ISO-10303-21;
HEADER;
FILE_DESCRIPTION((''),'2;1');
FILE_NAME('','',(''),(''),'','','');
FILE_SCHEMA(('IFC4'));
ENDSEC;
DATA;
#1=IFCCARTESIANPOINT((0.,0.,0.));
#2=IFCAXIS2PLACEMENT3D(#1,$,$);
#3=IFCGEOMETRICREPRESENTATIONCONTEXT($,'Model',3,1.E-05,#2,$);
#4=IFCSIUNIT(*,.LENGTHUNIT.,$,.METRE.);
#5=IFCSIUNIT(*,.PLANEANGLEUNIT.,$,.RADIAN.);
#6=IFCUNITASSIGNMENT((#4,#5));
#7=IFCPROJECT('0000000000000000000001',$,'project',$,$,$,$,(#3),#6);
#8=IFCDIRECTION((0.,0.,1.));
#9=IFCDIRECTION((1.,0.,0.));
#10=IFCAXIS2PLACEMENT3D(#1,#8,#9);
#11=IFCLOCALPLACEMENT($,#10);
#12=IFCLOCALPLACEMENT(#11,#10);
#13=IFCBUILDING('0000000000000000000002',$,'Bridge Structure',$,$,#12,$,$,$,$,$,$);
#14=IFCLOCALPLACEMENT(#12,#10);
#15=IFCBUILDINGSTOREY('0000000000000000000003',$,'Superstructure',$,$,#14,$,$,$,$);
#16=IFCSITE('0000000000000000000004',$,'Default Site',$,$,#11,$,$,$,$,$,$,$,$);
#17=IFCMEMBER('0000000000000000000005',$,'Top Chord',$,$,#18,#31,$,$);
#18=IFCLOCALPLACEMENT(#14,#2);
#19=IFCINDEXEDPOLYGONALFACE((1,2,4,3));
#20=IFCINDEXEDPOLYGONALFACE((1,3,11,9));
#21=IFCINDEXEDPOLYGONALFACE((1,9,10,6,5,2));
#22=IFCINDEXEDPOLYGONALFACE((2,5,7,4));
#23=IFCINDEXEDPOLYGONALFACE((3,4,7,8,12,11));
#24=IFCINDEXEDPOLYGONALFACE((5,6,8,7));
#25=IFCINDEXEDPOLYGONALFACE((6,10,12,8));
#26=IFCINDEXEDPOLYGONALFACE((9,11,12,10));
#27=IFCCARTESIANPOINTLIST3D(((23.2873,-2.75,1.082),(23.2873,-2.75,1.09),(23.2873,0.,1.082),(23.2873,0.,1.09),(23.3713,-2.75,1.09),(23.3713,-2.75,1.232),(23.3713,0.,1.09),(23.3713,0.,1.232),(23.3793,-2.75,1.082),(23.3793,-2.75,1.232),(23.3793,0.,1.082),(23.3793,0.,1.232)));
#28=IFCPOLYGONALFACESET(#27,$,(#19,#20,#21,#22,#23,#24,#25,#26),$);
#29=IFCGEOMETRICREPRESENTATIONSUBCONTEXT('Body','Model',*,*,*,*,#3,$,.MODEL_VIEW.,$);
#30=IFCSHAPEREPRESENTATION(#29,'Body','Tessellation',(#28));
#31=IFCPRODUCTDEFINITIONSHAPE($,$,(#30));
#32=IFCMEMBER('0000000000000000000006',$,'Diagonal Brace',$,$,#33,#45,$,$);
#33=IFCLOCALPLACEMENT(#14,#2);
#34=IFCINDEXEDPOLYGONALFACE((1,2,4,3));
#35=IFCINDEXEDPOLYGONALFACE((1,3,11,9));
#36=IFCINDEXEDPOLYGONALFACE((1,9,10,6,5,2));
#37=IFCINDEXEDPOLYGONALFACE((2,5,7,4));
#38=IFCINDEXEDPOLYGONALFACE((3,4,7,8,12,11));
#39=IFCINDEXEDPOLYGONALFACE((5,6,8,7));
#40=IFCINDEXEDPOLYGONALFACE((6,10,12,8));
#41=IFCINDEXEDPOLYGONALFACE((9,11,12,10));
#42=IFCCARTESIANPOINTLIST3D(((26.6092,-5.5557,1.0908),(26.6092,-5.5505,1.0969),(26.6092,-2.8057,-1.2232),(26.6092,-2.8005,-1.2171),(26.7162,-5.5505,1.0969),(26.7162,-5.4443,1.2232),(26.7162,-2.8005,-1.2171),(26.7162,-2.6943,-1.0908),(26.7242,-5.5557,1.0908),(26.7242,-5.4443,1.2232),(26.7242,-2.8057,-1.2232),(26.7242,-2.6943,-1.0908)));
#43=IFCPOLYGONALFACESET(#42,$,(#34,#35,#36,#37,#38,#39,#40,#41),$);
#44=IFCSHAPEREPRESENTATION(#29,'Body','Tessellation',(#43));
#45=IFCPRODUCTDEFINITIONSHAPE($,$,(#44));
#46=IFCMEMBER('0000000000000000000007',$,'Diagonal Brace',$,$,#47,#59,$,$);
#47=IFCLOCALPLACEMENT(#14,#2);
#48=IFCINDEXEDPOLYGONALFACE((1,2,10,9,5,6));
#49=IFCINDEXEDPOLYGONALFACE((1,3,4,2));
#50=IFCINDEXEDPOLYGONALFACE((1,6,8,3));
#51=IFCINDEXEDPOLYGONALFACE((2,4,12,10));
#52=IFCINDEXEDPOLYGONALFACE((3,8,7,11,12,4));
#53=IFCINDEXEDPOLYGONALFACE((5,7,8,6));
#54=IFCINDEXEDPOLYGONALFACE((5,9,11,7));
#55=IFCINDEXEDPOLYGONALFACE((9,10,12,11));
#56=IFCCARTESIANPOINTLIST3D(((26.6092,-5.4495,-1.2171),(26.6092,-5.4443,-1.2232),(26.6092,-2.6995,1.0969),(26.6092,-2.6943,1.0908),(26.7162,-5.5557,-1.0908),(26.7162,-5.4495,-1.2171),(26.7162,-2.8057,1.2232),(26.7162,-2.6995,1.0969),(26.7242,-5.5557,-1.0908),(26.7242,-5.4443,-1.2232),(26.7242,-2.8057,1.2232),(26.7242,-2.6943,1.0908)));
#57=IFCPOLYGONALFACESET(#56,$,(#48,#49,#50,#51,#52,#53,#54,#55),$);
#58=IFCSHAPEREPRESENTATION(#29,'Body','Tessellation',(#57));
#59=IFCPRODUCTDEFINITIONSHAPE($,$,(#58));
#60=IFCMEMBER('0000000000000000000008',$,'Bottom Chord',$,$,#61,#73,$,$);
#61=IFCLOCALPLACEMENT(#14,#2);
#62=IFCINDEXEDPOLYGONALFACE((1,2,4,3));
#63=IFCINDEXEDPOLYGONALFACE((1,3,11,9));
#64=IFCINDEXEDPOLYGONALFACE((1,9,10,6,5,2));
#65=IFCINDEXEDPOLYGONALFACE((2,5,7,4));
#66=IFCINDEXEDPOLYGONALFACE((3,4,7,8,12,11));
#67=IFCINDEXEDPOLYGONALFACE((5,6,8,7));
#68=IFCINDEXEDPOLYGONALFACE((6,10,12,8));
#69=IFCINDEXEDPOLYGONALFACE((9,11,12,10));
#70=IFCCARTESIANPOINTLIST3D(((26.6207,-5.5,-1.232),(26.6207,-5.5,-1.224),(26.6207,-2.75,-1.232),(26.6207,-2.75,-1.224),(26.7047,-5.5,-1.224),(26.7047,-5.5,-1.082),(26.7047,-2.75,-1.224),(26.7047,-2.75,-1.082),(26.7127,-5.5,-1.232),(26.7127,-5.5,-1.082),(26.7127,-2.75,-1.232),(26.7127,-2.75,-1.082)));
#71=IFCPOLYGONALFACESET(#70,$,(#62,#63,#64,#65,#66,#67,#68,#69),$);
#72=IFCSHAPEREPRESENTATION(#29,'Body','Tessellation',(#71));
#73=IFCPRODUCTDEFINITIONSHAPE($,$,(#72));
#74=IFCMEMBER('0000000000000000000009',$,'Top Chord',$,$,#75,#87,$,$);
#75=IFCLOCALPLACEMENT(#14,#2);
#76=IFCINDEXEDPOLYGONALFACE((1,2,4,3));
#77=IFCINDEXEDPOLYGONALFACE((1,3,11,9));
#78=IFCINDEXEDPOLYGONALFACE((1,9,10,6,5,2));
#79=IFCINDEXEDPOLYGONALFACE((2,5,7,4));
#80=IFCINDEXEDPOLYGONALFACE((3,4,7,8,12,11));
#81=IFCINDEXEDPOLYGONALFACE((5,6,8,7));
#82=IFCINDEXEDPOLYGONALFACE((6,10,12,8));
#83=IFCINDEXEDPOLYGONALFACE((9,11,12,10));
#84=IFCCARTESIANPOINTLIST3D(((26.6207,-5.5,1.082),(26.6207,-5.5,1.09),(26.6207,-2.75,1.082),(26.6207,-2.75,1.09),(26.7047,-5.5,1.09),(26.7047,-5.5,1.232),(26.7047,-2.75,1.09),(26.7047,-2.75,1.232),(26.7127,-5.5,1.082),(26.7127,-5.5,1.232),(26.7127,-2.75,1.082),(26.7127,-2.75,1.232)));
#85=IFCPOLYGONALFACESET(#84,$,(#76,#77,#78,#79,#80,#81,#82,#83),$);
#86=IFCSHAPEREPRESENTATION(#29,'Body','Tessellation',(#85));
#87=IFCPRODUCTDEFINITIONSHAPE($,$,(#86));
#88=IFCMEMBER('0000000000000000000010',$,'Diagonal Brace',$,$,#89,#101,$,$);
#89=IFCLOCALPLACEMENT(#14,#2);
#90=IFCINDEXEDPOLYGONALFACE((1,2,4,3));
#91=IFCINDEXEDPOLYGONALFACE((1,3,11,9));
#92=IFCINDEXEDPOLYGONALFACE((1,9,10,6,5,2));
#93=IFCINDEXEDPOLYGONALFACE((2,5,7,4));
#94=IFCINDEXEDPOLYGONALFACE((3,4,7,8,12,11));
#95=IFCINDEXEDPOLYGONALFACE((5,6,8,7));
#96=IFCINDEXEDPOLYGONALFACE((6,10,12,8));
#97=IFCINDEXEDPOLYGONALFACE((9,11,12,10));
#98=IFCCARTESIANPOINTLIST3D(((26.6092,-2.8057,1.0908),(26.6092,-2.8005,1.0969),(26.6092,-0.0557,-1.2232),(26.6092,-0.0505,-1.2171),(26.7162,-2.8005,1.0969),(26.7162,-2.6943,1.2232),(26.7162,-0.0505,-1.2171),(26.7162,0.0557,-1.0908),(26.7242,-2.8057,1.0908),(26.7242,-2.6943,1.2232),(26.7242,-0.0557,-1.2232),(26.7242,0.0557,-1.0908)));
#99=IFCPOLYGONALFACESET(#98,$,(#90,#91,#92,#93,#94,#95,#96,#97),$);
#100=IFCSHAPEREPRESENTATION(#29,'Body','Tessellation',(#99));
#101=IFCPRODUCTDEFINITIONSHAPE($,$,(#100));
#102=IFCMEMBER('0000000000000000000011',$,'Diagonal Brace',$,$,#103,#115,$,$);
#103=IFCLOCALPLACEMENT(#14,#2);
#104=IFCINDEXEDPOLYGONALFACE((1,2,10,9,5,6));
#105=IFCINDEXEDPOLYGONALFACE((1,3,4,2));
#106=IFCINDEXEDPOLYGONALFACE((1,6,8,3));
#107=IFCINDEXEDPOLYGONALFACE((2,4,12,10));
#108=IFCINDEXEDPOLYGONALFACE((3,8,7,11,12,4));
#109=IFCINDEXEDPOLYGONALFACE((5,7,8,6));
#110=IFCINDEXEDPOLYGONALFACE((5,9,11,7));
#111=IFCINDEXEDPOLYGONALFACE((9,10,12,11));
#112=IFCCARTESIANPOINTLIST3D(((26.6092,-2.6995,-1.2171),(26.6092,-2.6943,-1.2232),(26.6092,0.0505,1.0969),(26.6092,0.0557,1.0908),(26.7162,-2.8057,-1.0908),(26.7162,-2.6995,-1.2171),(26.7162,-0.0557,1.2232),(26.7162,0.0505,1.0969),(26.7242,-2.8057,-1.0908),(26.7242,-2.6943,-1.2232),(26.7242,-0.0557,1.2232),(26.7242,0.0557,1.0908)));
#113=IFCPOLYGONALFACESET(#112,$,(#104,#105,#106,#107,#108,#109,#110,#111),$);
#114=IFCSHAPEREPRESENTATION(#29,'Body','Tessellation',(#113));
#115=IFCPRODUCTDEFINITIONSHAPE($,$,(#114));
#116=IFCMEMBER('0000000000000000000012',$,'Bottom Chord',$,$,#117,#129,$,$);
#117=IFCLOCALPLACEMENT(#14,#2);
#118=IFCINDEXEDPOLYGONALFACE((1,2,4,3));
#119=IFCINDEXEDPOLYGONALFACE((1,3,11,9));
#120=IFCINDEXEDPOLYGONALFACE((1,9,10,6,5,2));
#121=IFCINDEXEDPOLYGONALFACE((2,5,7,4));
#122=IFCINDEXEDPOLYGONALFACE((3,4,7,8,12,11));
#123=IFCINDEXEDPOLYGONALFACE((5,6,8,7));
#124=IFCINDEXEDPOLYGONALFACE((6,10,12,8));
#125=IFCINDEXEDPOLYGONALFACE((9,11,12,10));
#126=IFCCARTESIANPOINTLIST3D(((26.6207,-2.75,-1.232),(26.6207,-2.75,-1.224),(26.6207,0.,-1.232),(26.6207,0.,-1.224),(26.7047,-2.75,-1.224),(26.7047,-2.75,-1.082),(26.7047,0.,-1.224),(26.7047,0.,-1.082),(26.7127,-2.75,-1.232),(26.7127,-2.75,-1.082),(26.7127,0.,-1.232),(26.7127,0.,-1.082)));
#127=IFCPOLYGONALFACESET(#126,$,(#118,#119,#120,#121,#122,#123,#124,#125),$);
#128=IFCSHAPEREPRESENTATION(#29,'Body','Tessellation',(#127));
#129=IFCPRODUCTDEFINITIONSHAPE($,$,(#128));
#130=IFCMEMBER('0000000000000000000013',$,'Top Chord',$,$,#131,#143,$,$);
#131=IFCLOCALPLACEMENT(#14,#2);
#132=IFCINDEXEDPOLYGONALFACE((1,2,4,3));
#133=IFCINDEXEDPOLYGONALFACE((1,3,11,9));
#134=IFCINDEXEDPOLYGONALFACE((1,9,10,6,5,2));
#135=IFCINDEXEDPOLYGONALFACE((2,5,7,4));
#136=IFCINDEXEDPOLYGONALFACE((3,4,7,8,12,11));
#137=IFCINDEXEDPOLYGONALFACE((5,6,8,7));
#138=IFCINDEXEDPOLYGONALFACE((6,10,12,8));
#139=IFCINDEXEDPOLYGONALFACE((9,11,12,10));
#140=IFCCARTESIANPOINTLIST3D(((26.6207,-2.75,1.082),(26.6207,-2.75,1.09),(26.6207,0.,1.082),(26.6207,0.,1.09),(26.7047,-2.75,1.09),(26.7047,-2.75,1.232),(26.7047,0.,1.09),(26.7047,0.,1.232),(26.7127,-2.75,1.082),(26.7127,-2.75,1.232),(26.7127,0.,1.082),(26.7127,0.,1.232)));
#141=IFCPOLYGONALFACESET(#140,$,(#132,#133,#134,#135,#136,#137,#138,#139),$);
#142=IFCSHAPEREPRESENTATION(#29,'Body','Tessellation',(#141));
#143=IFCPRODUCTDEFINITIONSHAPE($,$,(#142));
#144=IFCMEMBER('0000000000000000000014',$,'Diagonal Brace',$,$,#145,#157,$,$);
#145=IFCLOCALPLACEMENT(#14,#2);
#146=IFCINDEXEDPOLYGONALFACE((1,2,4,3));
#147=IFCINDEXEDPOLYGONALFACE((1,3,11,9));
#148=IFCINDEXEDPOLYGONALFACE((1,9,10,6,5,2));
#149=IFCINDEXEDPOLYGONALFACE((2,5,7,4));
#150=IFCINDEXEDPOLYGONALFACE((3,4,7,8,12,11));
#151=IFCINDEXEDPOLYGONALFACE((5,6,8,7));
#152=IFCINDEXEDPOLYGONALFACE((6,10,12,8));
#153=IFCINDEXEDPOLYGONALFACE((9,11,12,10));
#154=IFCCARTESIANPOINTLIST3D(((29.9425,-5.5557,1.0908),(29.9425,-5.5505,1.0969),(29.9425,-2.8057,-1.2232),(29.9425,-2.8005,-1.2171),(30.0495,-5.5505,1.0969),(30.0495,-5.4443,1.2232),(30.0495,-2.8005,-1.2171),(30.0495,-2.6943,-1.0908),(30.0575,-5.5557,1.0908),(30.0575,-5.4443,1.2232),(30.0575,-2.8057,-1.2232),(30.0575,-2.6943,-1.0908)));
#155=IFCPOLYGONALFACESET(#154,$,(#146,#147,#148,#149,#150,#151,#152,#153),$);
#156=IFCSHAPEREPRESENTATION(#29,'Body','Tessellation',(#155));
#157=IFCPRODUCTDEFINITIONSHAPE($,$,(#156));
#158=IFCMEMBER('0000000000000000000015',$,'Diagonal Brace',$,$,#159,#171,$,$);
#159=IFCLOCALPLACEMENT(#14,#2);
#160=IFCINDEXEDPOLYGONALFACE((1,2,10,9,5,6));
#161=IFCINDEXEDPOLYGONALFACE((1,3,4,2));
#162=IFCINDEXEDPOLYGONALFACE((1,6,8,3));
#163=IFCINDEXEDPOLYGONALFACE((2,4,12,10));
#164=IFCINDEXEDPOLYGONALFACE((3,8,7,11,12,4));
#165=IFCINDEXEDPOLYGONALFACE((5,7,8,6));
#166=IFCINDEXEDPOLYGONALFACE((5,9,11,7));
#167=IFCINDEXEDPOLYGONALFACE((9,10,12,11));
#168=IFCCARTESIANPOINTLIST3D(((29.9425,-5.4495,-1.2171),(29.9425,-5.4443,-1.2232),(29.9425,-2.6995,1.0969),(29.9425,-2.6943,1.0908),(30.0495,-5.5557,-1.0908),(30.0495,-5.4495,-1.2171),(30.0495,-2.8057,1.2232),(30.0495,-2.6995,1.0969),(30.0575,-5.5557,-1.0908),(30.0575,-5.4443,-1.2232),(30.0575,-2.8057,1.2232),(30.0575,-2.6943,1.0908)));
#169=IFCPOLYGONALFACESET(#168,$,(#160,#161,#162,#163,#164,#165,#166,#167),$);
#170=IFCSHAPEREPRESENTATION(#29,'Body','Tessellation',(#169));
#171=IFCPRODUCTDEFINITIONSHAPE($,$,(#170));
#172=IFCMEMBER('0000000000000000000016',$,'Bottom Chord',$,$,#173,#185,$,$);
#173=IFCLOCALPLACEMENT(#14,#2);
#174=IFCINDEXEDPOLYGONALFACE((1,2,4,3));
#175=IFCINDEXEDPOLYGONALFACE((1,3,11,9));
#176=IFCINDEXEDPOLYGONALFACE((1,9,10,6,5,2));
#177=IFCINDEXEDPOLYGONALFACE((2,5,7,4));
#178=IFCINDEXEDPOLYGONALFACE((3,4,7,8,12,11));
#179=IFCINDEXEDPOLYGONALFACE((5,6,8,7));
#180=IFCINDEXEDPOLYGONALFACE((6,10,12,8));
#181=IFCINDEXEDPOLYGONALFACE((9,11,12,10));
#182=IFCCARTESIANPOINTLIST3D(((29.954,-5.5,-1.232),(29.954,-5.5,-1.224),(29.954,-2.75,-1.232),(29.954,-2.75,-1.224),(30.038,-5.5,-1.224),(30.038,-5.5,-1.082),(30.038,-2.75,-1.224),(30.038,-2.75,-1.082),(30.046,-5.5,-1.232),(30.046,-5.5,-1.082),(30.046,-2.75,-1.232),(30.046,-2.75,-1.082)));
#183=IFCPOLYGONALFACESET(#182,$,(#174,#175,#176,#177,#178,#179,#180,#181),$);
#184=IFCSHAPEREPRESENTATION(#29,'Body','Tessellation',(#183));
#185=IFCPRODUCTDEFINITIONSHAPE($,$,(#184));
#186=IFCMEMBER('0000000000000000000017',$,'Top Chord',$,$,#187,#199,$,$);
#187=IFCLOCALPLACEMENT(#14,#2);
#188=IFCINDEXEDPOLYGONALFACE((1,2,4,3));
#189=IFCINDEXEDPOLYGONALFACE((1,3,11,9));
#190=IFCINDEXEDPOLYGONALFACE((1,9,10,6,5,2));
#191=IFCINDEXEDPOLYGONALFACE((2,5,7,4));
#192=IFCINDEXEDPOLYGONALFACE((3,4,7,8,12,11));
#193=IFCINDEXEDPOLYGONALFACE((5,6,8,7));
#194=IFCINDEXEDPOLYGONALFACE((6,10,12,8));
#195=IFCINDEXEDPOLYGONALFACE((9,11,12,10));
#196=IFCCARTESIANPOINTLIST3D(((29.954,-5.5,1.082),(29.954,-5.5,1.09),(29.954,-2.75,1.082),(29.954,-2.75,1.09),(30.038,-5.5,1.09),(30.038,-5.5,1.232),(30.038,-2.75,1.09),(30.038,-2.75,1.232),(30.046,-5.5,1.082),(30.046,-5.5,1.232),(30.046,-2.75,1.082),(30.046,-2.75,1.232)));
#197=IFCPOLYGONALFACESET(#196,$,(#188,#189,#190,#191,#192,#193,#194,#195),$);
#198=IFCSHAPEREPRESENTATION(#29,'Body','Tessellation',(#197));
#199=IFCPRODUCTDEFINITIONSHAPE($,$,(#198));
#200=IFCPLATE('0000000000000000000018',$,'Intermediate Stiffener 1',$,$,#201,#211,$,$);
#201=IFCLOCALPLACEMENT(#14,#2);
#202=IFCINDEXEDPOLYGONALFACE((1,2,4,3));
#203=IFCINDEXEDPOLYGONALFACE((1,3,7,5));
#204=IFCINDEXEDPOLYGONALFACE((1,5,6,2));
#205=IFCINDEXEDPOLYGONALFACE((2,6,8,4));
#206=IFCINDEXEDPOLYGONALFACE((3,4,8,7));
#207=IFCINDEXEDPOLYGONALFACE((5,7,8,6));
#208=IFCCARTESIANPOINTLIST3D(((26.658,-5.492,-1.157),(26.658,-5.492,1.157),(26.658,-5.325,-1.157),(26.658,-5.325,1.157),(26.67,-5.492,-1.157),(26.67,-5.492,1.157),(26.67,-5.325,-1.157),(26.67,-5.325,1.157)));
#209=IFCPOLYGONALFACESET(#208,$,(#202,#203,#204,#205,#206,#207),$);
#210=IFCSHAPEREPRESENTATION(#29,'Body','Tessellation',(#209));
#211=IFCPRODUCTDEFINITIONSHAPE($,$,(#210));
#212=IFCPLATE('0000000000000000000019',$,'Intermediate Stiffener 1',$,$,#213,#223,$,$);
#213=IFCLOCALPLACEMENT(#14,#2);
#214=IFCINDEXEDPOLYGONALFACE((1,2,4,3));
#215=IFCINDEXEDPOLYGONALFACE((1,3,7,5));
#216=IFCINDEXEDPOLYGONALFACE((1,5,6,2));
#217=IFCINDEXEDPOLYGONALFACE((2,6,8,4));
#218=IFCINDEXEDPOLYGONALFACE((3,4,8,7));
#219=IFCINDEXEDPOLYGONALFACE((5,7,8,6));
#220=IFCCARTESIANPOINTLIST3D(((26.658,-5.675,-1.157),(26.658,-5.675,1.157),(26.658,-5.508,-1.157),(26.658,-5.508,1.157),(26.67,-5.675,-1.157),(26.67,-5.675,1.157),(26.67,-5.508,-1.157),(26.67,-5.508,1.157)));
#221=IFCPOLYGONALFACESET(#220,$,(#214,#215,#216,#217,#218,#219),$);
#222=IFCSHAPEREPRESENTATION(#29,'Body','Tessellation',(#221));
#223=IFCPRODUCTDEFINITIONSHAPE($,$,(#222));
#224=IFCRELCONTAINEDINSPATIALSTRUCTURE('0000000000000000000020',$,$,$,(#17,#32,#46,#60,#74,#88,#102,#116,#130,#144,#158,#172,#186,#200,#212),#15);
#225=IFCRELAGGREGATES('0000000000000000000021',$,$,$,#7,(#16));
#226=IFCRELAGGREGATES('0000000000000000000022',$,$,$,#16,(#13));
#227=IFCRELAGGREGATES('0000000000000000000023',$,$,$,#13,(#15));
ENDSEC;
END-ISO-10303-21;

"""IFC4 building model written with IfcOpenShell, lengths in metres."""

from ifc_helpers import new_model, si_unit, frame, origin, origin_with_axes, origin_2d_with_axis, place, context, subcontext, project, spatial, rectangle, l_section, extrude, element, save


model = new_model("IFC4")

# Units and contexts
model_context = context("Model", 3, precision=1e-05, world=origin())
body_context = subcontext(model_context, "Body", "Model", "MODEL_VIEW")
ifc_project = project(units=[si_unit("LENGTHUNIT", "METRE"), si_unit("PLANEANGLEUNIT", "RADIAN")], contexts=[model_context])

# Site, building, storey
site_placement = place(None, origin_with_axes())
site = spatial("IfcSite", under=ifc_project, at=site_placement, Name="Default Site")
building_placement = place(site_placement, origin_with_axes())
building = spatial("IfcBuilding", under=site, at=building_placement, Name="Bridge Structure")
storey_placement = place(building_placement, origin_with_axes())
storey = spatial("IfcBuildingStorey", under=building, at=storey_placement, Name="Superstructure")

# Members
member_placement = place(storey_placement, frame((23.3333, -2.75, 1.157), z_axis=(0.0, 1.0, 0.0), x_axis=(-1.0, 0.0, 0.0)))
element("IfcMember", 1, at=member_placement, inside=storey, Name="Top Chord", context=body_context, shape_type="SweptSolid", body=[
    extrude(l_section(Depth=0.15, Width=0.092, Thickness=0.008, at=origin_2d_with_axis()), origin_with_axes(), (0.0, 0.0, 1.0), 2.75),
])
for number, where, z_axis, x_axis, name in (
    (2, (26.6667, -5.5, 1.157), (0.0, 0.765156, -0.643844), (-1.0, 0.0, 0.0), "Diagonal Brace"),
    (3, (26.6667, -5.5, -1.157), (0.0, 0.765156, 0.643844), (-1.0, 0.0, 0.0), "Diagonal Brace"),
):
    element("IfcMember", number, at=place(storey_placement, frame(where, z_axis=z_axis, x_axis=x_axis)), inside=storey, Name=name, context=body_context, shape_type="SweptSolid", body=[
        extrude(l_section(Depth=0.173, Width=0.115, Thickness=0.008, at=origin_2d_with_axis()), origin_with_axes(), (0.0, 0.0, 1.0), 3.594),
    ])
for number, where, z_axis, x_axis, name in (
    (4, (26.6667, -5.5, -1.157), (0.0, 1.0, 0.0), (-1.0, 0.0, 0.0), "Bottom Chord"),
    (5, (26.6667, -5.5, 1.157), (0.0, 1.0, 0.0), (-1.0, 0.0, 0.0), "Top Chord"),
):
    element("IfcMember", number, at=place(storey_placement, frame(where, z_axis=z_axis, x_axis=x_axis)), inside=storey, Name=name, context=body_context, shape_type="SweptSolid", body=[
        extrude(l_section(Depth=0.15, Width=0.092, Thickness=0.008, at=origin_2d_with_axis()), origin_with_axes(), (0.0, 0.0, 1.0), 2.75),
    ])
for number, where, z_axis, x_axis, name in (
    (6, (26.6667, -2.75, 1.157), (0.0, 0.765156, -0.643844), (-1.0, 0.0, 0.0), "Diagonal Brace"),
    (7, (26.6667, -2.75, -1.157), (0.0, 0.765156, 0.643844), (-1.0, 0.0, 0.0), "Diagonal Brace"),
):
    element("IfcMember", number, at=place(storey_placement, frame(where, z_axis=z_axis, x_axis=x_axis)), inside=storey, Name=name, context=body_context, shape_type="SweptSolid", body=[
        extrude(l_section(Depth=0.173, Width=0.115, Thickness=0.008, at=origin_2d_with_axis()), origin_with_axes(), (0.0, 0.0, 1.0), 3.594),
    ])
for number, where, z_axis, x_axis, name in (
    (8, (26.6667, -2.75, -1.157), (0.0, 1.0, 0.0), (-1.0, 0.0, 0.0), "Bottom Chord"),
    (9, (26.6667, -2.75, 1.157), (0.0, 1.0, 0.0), (-1.0, 0.0, 0.0), "Top Chord"),
):
    element("IfcMember", number, at=place(storey_placement, frame(where, z_axis=z_axis, x_axis=x_axis)), inside=storey, Name=name, context=body_context, shape_type="SweptSolid", body=[
        extrude(l_section(Depth=0.15, Width=0.092, Thickness=0.008, at=origin_2d_with_axis()), origin_with_axes(), (0.0, 0.0, 1.0), 2.75),
    ])
for number, where, z_axis, x_axis, name in (
    (10, (30.0, -5.5, 1.157), (0.0, 0.765156, -0.643844), (-1.0, 0.0, 0.0), "Diagonal Brace"),
    (11, (30.0, -5.5, -1.157), (0.0, 0.765156, 0.643844), (-1.0, 0.0, 0.0), "Diagonal Brace"),
):
    element("IfcMember", number, at=place(storey_placement, frame(where, z_axis=z_axis, x_axis=x_axis)), inside=storey, Name=name, context=body_context, shape_type="SweptSolid", body=[
        extrude(l_section(Depth=0.173, Width=0.115, Thickness=0.008, at=origin_2d_with_axis()), origin_with_axes(), (0.0, 0.0, 1.0), 3.594),
    ])
for number, where, z_axis, x_axis, name in (
    (12, (30.0, -5.5, -1.157), (0.0, 1.0, 0.0), (-1.0, 0.0, 0.0), "Bottom Chord"),
    (13, (30.0, -5.5, 1.157), (0.0, 1.0, 0.0), (-1.0, 0.0, 0.0), "Top Chord"),
):
    element("IfcMember", number, at=place(storey_placement, frame(where, z_axis=z_axis, x_axis=x_axis)), inside=storey, Name=name, context=body_context, shape_type="SweptSolid", body=[
        extrude(l_section(Depth=0.15, Width=0.092, Thickness=0.008, at=origin_2d_with_axis()), origin_with_axes(), (0.0, 0.0, 1.0), 2.75),
    ])

# Plates
for number, where, z_axis, x_axis, name in (
    (14, (26.664, -5.4085, -1.157), (0.0, 0.0, 1.0), (1.0, 0.0, 0.0), "Intermediate Stiffener 1"),
    (15, (26.664, -5.5915, -1.157), (0.0, 0.0, 1.0), (1.0, 0.0, 0.0), "Intermediate Stiffener 1"),
):
    element("IfcPlate", number, at=place(storey_placement, frame(where, z_axis=z_axis, x_axis=x_axis)), inside=storey, Name=name, context=body_context, shape_type="SweptSolid", body=[
        extrude(rectangle(XDim=0.012, YDim=0.167, at=origin_2d_with_axis()), origin_with_axes(), (0.0, 0.0, 1.0), 2.314),
    ])

save(model, "model.ifc")
